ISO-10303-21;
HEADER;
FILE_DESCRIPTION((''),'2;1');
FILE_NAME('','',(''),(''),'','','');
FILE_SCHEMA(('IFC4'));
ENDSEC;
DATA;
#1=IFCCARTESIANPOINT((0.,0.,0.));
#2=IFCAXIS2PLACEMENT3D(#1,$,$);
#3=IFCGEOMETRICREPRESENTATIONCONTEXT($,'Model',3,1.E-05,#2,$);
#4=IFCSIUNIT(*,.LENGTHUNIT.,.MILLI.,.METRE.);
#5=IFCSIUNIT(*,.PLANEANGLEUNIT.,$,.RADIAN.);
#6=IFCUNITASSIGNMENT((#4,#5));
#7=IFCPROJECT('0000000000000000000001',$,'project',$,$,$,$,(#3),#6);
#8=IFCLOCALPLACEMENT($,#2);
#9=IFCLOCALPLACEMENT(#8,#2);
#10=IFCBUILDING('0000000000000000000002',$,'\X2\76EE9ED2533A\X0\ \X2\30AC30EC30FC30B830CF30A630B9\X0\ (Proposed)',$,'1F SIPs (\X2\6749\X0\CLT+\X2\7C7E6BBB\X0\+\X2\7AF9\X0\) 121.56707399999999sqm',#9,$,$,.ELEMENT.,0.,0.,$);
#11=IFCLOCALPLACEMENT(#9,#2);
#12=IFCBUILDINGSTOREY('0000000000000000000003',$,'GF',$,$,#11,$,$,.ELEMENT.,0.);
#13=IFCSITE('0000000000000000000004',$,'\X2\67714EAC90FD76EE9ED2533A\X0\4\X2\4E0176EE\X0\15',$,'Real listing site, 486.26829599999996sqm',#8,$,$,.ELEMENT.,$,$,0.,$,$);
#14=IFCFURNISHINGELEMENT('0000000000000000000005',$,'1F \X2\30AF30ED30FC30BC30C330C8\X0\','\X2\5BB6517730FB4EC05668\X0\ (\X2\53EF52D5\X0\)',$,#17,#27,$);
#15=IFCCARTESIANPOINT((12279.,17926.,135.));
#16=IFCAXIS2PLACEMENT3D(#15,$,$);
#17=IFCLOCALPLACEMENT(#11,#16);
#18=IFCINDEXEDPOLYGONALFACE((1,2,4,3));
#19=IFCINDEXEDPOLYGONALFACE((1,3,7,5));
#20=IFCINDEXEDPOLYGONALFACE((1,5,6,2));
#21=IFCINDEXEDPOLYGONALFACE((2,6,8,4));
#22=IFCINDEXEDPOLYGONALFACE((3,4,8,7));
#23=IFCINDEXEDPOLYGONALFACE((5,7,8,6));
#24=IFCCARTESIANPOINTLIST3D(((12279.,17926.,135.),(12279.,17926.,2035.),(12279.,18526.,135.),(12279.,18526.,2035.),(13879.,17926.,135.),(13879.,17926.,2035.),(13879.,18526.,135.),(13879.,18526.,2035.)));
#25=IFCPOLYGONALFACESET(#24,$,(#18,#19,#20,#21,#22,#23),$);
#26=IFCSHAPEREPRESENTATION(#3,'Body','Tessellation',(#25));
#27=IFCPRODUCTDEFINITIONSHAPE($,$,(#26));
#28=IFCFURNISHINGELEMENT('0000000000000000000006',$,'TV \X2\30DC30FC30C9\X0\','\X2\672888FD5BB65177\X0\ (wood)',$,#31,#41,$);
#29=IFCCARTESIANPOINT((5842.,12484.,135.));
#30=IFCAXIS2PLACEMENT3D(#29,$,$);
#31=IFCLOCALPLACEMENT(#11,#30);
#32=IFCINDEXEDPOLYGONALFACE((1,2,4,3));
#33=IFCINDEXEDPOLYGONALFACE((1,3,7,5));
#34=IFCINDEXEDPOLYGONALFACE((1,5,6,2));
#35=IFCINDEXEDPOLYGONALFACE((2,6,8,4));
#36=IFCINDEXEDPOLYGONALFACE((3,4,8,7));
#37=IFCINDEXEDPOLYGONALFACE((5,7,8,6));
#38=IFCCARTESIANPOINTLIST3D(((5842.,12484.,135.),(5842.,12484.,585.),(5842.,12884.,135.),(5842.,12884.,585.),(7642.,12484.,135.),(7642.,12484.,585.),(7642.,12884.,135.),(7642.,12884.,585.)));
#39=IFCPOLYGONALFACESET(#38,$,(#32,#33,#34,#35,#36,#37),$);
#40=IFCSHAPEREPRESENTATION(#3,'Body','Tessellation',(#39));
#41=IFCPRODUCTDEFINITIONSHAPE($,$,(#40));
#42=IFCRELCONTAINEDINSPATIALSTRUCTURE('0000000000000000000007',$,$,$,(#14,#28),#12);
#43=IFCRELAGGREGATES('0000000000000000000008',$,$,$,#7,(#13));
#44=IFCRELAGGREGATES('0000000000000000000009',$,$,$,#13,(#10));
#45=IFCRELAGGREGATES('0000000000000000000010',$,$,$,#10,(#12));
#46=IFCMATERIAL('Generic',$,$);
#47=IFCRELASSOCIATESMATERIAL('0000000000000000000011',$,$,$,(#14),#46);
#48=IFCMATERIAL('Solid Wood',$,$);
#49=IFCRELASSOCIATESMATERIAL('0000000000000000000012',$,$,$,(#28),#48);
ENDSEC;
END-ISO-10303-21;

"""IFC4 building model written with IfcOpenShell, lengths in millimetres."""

from ifc_helpers import new_model, si_unit, frame, frame_2d, origin, place, context, project, spatial, rectangle, extrude, material, element, save


model = new_model("IFC4")

# Units and contexts
model_context = context("Model", 3, precision=1e-05, world=origin())
ifc_project = project(units=[si_unit("LENGTHUNIT", "METRE", prefix="MILLI"), si_unit("PLANEANGLEUNIT", "RADIAN")], contexts=[model_context])

# Site, building, storey
site_placement = place(None, origin())
site = spatial("IfcSite", under=ifc_project, at=site_placement, Name="東京都目黒区4丁目15", ObjectType="Real listing site, 486.26829599999996sqm", CompositionType="ELEMENT", RefElevation=0.0)
building_placement = place(site_placement, origin())
building = spatial("IfcBuilding", under=site, at=building_placement, Name="目黒区 ガレージハウス (Proposed)", ObjectType="1F SIPs (杉CLT+籾殻+竹) 121.56707399999999sqm", CompositionType="ELEMENT", ElevationOfRefHeight=0.0, ElevationOfTerrain=0.0)
storey_placement = place(building_placement, origin())
storey = spatial("IfcBuildingStorey", under=building, at=storey_placement, Name="GF", CompositionType="ELEMENT", Elevation=0.0)

# Shared definitions
ifc_material_1 = material(Name="Solid Wood")

# Shared definitions
ifc_material_2 = material(Name="Generic")

# Furnishing elements
furnishing_1_placement = place(storey_placement, frame((12279.0, 17926.0, 135.0)))
element("IfcFurnishingElement", 1, at=furnishing_1_placement, inside=storey, material=ifc_material_2, Name="1F クローゼット", Description="家具・什器 (可動)", context=model_context, shape_type="SweptSolid", body=[
    extrude(rectangle(XDim=1600.0, YDim=600.0, at=frame_2d((800.0, 300.0))), frame((12279.0, 17926.0, 135.0)), (0.0, 0.0, 1.0), 1900.0),
])
furnishing_2_placement = place(storey_placement, frame((5842.0, 12484.0, 135.0)))
element("IfcFurnishingElement", 2, at=furnishing_2_placement, inside=storey, material=ifc_material_1, Name="TV ボード", Description="木製家具 (wood)", context=model_context, shape_type="SweptSolid", body=[
    extrude(rectangle(XDim=1800.0, YDim=400.0, at=frame_2d((900.0, 200.0))), frame((5842.0, 12484.0, 135.0)), (0.0, 0.0, 1.0), 450.0),
])

save(model, "model.ifc")
